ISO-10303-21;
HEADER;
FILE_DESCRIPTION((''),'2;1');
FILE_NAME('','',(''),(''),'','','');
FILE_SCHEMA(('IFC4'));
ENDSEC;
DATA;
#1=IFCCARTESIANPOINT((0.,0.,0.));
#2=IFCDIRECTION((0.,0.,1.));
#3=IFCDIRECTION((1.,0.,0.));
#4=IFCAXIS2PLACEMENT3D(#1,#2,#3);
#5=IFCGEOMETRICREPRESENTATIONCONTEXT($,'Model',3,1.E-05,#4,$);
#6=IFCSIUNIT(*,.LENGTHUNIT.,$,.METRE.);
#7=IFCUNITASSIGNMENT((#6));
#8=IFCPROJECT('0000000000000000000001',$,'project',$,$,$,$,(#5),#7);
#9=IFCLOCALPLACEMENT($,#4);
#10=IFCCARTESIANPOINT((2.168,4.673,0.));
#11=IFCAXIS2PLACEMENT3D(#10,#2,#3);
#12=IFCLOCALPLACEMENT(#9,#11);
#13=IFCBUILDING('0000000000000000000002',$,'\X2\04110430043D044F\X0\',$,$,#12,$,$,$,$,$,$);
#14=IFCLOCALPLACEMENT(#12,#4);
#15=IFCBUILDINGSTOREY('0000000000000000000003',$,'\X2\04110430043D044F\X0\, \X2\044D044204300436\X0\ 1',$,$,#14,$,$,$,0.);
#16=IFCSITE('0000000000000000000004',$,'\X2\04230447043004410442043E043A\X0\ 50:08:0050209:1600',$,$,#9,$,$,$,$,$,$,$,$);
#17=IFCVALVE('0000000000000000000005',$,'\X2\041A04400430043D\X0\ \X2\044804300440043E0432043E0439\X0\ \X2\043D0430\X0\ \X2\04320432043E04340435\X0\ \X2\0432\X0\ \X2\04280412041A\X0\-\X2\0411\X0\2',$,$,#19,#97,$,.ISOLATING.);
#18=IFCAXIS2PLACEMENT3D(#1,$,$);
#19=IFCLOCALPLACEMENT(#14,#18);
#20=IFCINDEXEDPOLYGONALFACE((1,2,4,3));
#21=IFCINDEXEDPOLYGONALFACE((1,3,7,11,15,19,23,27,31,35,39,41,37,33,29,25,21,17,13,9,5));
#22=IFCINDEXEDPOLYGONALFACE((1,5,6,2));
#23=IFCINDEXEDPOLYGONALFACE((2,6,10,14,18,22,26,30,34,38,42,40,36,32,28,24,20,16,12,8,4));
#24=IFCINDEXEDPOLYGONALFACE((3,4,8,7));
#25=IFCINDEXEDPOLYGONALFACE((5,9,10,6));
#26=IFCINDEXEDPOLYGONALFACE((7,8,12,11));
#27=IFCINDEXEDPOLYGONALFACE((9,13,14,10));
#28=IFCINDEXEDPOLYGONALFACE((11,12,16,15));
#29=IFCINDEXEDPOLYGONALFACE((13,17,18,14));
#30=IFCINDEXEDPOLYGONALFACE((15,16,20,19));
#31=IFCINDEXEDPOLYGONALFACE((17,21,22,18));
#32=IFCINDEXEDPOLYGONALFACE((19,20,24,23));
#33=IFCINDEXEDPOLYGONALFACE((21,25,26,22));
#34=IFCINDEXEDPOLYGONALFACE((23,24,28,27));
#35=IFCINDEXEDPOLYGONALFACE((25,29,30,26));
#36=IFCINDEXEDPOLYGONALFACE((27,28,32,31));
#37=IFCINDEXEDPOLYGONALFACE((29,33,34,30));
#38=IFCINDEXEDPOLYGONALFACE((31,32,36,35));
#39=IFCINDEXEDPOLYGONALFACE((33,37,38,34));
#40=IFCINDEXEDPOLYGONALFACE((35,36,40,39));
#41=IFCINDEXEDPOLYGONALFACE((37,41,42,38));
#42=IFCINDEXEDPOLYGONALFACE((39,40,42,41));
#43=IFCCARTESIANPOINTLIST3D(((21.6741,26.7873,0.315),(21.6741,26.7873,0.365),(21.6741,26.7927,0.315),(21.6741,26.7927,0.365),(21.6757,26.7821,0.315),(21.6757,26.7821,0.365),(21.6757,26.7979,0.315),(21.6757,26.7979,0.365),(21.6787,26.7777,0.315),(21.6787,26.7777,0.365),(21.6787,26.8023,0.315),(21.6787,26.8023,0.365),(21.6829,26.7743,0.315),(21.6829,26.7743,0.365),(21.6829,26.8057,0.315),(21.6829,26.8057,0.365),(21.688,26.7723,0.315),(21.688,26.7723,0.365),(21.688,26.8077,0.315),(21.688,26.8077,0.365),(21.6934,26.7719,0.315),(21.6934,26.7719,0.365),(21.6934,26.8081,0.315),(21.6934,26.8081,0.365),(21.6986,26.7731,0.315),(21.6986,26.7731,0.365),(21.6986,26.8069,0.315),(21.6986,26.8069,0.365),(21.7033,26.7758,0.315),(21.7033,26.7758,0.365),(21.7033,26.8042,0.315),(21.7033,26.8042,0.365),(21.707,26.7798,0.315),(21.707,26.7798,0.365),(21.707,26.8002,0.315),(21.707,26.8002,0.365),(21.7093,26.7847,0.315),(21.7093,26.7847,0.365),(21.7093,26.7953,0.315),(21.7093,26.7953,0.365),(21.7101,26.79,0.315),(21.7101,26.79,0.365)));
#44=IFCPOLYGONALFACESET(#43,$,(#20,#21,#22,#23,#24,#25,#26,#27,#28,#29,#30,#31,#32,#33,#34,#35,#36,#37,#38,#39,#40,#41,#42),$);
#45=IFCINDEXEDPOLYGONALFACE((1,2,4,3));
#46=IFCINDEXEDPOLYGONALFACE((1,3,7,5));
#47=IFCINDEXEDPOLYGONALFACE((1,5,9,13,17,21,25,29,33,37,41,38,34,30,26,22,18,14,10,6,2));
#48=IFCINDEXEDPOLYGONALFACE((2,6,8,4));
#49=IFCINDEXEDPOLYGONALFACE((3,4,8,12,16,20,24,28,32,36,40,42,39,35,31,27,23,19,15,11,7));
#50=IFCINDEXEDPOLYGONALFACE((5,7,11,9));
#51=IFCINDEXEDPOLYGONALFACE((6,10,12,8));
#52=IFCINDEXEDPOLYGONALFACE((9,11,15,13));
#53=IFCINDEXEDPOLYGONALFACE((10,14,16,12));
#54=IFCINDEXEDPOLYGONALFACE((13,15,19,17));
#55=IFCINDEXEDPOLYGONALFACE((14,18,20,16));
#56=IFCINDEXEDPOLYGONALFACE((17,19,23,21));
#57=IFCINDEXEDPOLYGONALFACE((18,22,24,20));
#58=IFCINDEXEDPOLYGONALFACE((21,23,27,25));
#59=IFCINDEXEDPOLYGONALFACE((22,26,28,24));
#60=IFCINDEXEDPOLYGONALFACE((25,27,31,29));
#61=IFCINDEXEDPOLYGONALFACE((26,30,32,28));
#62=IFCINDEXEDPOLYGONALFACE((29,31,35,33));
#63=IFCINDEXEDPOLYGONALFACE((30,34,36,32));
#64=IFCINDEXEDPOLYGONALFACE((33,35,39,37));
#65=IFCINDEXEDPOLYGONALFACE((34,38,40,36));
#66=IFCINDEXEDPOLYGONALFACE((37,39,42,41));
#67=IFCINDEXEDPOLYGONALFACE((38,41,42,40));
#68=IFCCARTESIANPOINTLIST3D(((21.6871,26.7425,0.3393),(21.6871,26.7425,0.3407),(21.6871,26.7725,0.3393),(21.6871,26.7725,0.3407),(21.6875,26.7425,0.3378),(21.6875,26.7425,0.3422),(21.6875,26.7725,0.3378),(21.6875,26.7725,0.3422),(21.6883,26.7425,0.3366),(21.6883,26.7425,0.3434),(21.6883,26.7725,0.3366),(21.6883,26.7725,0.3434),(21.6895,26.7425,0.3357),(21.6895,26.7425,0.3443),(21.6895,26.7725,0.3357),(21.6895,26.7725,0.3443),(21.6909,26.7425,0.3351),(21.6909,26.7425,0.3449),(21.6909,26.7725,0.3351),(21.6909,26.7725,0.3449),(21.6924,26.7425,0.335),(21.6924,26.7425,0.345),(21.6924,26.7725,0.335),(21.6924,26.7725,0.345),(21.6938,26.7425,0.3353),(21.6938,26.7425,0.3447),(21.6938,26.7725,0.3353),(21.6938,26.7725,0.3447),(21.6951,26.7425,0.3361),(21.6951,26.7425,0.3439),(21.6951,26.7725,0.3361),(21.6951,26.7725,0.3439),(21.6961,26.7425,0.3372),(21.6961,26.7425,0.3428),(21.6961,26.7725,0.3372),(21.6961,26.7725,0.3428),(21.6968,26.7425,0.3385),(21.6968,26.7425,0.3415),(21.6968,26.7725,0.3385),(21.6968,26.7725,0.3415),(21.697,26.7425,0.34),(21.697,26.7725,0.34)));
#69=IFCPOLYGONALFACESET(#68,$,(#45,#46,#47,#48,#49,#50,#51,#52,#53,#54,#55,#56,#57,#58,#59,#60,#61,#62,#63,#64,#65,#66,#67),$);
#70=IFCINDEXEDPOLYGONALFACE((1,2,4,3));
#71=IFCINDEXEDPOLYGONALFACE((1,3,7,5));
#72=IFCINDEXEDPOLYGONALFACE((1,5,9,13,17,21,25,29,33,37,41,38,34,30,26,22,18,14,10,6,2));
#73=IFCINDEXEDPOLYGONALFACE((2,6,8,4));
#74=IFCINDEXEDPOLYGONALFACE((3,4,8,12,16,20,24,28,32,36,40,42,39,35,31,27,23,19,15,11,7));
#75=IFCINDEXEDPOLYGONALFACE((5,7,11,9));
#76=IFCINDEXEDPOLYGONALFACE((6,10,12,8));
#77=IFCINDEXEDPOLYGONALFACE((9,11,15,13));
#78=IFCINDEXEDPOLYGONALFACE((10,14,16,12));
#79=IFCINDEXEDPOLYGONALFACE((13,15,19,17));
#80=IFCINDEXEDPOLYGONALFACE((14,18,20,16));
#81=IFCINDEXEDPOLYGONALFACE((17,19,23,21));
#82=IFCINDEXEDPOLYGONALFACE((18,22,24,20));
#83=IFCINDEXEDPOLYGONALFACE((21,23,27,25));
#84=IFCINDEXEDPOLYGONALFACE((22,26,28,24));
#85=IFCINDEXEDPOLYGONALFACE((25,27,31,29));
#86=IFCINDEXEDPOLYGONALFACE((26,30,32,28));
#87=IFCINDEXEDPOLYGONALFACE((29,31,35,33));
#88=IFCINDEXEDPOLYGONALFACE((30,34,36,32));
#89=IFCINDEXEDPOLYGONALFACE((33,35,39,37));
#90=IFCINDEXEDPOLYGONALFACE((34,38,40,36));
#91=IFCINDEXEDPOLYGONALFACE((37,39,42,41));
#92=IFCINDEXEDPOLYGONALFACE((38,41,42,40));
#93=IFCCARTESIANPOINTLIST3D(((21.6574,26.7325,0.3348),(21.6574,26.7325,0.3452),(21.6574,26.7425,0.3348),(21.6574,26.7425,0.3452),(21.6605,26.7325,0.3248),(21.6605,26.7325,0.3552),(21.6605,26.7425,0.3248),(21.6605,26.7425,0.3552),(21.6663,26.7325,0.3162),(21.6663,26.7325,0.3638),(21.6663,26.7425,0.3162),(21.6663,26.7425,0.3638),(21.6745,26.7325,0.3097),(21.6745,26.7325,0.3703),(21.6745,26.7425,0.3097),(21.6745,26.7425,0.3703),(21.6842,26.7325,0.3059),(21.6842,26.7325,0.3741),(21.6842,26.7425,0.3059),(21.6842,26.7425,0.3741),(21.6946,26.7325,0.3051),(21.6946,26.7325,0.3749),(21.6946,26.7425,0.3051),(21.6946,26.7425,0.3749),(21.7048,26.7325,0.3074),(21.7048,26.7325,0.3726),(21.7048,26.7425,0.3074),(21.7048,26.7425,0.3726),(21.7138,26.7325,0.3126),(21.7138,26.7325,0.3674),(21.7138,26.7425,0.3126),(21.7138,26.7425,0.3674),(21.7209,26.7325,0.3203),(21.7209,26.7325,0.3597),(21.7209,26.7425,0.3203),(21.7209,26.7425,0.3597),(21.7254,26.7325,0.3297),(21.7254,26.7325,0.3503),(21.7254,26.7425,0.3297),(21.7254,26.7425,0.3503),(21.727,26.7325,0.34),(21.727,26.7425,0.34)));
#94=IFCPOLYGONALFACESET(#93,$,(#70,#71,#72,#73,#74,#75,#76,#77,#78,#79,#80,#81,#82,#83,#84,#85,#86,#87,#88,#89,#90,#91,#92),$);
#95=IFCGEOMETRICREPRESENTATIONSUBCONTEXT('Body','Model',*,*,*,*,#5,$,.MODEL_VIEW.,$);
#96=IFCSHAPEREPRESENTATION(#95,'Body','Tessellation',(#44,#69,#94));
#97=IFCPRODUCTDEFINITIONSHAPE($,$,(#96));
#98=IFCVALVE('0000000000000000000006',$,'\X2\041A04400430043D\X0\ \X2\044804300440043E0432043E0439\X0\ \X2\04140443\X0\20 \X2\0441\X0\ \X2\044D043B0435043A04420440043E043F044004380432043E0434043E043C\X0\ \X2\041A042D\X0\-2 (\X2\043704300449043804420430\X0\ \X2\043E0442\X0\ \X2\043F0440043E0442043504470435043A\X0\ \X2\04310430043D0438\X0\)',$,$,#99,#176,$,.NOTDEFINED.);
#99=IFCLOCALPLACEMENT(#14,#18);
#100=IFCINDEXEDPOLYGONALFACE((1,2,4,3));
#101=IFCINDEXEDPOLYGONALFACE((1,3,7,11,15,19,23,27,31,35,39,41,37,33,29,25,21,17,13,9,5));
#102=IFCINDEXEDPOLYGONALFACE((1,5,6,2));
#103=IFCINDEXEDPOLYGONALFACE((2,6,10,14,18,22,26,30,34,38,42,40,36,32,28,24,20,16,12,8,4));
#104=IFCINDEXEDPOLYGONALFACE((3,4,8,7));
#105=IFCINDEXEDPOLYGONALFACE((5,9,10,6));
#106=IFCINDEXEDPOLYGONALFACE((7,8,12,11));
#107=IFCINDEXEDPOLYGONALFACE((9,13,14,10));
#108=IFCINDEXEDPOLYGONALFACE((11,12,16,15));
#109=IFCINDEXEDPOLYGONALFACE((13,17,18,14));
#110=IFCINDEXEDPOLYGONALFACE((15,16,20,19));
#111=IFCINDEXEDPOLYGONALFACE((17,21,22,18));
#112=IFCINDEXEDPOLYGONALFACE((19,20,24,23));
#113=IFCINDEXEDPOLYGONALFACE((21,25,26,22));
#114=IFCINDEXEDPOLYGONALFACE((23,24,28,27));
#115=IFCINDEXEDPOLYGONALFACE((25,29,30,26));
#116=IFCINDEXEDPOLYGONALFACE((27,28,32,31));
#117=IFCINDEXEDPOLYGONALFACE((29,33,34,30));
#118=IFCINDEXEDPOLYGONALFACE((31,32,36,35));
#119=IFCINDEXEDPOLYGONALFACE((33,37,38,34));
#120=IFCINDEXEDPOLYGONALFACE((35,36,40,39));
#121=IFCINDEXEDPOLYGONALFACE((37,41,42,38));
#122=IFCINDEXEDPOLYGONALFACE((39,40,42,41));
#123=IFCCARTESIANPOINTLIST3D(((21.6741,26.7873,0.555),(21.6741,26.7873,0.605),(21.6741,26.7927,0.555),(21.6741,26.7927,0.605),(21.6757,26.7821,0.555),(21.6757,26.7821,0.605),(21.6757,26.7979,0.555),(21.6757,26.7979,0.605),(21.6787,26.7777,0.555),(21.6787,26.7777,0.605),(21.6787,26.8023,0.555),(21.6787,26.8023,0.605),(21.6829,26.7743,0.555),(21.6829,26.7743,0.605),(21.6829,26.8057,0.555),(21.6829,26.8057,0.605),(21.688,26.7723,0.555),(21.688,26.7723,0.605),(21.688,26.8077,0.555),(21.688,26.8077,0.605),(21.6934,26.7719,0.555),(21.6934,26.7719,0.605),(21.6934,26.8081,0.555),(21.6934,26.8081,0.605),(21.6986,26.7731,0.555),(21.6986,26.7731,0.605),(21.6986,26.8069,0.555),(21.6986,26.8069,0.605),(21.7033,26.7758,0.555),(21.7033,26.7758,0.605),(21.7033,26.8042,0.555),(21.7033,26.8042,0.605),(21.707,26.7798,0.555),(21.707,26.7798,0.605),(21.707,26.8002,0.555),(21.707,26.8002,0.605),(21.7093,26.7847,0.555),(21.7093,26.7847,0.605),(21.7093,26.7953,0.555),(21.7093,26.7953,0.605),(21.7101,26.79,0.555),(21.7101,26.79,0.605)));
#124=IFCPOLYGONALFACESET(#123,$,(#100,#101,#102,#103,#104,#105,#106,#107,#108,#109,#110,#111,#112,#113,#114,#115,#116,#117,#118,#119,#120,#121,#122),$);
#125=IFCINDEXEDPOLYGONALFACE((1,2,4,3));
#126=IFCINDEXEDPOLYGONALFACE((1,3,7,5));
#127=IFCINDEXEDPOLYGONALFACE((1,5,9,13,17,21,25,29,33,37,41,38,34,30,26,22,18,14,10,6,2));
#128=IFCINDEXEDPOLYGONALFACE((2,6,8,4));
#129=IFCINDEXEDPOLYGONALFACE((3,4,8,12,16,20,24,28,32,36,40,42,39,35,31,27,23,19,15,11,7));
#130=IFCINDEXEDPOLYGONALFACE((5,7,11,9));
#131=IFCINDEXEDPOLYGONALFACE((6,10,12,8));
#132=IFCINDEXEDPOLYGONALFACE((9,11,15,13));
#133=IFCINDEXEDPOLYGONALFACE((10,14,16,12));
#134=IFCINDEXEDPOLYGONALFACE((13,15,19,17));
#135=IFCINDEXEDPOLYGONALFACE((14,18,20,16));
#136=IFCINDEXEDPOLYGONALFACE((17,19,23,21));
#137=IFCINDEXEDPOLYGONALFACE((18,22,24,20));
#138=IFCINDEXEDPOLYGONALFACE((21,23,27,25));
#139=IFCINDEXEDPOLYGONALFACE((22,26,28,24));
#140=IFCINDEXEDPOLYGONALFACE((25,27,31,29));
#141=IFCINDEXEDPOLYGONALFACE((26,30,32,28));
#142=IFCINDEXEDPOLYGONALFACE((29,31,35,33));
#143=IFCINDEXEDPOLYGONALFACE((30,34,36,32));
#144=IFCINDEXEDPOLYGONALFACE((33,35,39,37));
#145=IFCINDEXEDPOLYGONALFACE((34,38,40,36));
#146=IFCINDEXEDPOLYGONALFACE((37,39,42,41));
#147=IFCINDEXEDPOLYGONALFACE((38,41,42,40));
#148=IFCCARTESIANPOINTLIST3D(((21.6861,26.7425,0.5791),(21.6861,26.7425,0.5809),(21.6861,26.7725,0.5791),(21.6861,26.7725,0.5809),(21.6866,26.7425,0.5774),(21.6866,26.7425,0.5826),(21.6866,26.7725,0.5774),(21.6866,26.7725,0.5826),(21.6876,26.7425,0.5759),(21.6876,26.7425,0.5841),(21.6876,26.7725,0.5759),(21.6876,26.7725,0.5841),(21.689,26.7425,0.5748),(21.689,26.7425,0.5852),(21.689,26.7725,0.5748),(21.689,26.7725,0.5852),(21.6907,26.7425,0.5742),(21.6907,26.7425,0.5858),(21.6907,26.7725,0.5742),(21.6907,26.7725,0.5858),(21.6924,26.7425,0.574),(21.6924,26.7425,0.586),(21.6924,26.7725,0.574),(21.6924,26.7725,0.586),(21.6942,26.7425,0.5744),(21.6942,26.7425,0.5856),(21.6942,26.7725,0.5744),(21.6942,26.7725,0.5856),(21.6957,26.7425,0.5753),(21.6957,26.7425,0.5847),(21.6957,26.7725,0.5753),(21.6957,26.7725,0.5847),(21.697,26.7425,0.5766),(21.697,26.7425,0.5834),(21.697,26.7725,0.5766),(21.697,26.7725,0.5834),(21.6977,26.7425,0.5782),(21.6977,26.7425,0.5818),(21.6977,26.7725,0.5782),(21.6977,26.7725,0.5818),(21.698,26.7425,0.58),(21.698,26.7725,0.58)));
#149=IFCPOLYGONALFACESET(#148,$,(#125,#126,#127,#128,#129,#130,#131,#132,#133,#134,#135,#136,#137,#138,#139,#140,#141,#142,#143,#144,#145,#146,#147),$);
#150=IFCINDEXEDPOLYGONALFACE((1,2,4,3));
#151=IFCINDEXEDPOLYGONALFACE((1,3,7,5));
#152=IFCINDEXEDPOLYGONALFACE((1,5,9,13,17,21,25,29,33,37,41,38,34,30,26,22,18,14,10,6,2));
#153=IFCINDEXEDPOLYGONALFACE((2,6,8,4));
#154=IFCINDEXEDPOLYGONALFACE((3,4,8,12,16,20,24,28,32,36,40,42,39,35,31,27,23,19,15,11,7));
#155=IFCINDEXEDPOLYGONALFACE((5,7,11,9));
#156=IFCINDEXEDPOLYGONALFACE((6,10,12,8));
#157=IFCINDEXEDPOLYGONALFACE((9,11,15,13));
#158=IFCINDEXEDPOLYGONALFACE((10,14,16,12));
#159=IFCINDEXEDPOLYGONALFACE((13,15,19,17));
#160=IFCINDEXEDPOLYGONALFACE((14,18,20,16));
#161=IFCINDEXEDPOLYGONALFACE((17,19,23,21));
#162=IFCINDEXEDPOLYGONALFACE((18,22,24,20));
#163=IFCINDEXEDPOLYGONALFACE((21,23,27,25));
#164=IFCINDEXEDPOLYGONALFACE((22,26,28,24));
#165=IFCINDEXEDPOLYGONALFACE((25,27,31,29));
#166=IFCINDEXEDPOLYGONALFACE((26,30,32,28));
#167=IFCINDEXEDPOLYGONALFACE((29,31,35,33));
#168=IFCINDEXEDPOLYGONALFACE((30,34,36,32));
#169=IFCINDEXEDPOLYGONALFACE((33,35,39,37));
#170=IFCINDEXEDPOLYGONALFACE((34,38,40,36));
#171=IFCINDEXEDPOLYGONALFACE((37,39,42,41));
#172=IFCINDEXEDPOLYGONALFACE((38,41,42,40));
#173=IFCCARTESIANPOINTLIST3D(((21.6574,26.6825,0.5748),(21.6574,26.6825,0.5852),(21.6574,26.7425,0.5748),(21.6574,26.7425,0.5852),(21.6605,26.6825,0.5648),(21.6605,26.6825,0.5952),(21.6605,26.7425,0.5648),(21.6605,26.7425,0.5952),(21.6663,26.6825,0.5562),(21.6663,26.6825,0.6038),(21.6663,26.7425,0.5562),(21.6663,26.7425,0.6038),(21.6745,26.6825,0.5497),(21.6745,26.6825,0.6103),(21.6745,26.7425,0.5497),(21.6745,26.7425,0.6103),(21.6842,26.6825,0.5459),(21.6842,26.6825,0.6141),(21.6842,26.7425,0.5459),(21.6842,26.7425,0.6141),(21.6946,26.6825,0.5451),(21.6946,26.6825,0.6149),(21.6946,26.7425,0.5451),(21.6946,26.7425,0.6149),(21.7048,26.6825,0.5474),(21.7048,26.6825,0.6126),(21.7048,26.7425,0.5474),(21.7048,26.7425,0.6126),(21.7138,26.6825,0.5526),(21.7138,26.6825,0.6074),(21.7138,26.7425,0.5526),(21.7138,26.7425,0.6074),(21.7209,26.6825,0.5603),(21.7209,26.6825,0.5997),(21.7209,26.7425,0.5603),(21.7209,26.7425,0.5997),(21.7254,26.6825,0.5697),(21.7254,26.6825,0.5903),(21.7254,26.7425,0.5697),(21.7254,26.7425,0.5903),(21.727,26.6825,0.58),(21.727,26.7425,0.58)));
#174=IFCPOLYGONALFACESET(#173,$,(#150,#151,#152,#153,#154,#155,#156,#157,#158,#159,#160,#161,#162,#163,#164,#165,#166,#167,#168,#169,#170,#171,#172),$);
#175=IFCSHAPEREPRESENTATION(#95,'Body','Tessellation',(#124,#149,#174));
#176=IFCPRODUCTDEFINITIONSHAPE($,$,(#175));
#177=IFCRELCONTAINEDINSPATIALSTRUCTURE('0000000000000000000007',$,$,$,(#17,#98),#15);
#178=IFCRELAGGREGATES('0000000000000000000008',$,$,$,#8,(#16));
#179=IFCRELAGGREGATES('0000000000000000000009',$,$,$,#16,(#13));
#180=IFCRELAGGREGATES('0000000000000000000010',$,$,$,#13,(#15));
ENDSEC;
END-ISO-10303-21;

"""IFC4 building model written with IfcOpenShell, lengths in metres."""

from ifc_helpers import new_model, si_unit, frame, origin_with_axes, origin_2d, place, context, subcontext, project, spatial, circle, extrude, element, save


model = new_model("IFC4")

# Units and contexts
model_context = context("Model", 3, precision=1e-05, world=origin_with_axes())
body_context = subcontext(model_context, "Body", "Model", "MODEL_VIEW")
ifc_project = project(units=[si_unit("LENGTHUNIT", "METRE")], contexts=[model_context])

# Site, building, storey
site_placement = place(None, origin_with_axes())
site = spatial("IfcSite", under=ifc_project, at=site_placement, Name="Участок 50:08:0050209:1600")
building_placement = place(site_placement, frame((2.168, 4.673, 0.0), z_axis=(0.0, 0.0, 1.0), x_axis=(1.0, 0.0, 0.0)))
building = spatial("IfcBuilding", under=site, at=building_placement, Name="Баня")
storey_placement = place(building_placement, origin_with_axes())
storey = spatial("IfcBuildingStorey", under=building, at=storey_placement, Name="Баня, этаж 1", Elevation=0.0)

# Valves
valve_1_placement = place(storey_placement, origin_with_axes())
element("IfcValve", 1, at=valve_1_placement, inside=storey, Name="Кран шаровой на вводе в ШВК-Б2", PredefinedType="ISOLATING", context=body_context, shape_type="SweptSolid", body=[
    extrude(circle(Radius=0.0181, at=origin_2d()), frame((21.692, 26.79, 0.315), z_axis=(0.0, 0.0, 1.0), x_axis=(1.0, 0.0, 0.0)), (0.0, 0.0, 1.0), 0.05),
    extrude(circle(Radius=0.005, at=origin_2d()), frame((21.692, 26.7725, 0.34), z_axis=(0.0, -1.0, 0.0), x_axis=(1.0, 0.0, 0.0)), (0.0, 0.0, 1.0), 0.03),
    extrude(circle(Radius=0.035, at=origin_2d()), frame((21.692, 26.7425, 0.34), z_axis=(0.0, -1.0, 0.0), x_axis=(1.0, 0.0, 0.0)), (0.0, 0.0, 1.0), 0.01),
])
valve_2_placement = place(storey_placement, origin_with_axes())
element("IfcValve", 2, at=valve_2_placement, inside=storey, Name="Кран шаровой Ду20 с электроприводом КЭ-2 (защита от протечек бани)", PredefinedType="NOTDEFINED", context=body_context, shape_type="SweptSolid", body=[
    extrude(circle(Radius=0.0181, at=origin_2d()), frame((21.692, 26.79, 0.555), z_axis=(0.0, 0.0, 1.0), x_axis=(1.0, 0.0, 0.0)), (0.0, 0.0, 1.0), 0.05),
    extrude(circle(Radius=0.006, at=origin_2d()), frame((21.692, 26.7725, 0.58), z_axis=(0.0, -1.0, 0.0), x_axis=(1.0, 0.0, 0.0)), (0.0, 0.0, 1.0), 0.03),
    extrude(circle(Radius=0.035, at=origin_2d()), frame((21.692, 26.7425, 0.58), z_axis=(0.0, -1.0, 0.0), x_axis=(1.0, 0.0, 0.0)), (0.0, 0.0, 1.0), 0.06),
])

save(model, "model.ifc")
